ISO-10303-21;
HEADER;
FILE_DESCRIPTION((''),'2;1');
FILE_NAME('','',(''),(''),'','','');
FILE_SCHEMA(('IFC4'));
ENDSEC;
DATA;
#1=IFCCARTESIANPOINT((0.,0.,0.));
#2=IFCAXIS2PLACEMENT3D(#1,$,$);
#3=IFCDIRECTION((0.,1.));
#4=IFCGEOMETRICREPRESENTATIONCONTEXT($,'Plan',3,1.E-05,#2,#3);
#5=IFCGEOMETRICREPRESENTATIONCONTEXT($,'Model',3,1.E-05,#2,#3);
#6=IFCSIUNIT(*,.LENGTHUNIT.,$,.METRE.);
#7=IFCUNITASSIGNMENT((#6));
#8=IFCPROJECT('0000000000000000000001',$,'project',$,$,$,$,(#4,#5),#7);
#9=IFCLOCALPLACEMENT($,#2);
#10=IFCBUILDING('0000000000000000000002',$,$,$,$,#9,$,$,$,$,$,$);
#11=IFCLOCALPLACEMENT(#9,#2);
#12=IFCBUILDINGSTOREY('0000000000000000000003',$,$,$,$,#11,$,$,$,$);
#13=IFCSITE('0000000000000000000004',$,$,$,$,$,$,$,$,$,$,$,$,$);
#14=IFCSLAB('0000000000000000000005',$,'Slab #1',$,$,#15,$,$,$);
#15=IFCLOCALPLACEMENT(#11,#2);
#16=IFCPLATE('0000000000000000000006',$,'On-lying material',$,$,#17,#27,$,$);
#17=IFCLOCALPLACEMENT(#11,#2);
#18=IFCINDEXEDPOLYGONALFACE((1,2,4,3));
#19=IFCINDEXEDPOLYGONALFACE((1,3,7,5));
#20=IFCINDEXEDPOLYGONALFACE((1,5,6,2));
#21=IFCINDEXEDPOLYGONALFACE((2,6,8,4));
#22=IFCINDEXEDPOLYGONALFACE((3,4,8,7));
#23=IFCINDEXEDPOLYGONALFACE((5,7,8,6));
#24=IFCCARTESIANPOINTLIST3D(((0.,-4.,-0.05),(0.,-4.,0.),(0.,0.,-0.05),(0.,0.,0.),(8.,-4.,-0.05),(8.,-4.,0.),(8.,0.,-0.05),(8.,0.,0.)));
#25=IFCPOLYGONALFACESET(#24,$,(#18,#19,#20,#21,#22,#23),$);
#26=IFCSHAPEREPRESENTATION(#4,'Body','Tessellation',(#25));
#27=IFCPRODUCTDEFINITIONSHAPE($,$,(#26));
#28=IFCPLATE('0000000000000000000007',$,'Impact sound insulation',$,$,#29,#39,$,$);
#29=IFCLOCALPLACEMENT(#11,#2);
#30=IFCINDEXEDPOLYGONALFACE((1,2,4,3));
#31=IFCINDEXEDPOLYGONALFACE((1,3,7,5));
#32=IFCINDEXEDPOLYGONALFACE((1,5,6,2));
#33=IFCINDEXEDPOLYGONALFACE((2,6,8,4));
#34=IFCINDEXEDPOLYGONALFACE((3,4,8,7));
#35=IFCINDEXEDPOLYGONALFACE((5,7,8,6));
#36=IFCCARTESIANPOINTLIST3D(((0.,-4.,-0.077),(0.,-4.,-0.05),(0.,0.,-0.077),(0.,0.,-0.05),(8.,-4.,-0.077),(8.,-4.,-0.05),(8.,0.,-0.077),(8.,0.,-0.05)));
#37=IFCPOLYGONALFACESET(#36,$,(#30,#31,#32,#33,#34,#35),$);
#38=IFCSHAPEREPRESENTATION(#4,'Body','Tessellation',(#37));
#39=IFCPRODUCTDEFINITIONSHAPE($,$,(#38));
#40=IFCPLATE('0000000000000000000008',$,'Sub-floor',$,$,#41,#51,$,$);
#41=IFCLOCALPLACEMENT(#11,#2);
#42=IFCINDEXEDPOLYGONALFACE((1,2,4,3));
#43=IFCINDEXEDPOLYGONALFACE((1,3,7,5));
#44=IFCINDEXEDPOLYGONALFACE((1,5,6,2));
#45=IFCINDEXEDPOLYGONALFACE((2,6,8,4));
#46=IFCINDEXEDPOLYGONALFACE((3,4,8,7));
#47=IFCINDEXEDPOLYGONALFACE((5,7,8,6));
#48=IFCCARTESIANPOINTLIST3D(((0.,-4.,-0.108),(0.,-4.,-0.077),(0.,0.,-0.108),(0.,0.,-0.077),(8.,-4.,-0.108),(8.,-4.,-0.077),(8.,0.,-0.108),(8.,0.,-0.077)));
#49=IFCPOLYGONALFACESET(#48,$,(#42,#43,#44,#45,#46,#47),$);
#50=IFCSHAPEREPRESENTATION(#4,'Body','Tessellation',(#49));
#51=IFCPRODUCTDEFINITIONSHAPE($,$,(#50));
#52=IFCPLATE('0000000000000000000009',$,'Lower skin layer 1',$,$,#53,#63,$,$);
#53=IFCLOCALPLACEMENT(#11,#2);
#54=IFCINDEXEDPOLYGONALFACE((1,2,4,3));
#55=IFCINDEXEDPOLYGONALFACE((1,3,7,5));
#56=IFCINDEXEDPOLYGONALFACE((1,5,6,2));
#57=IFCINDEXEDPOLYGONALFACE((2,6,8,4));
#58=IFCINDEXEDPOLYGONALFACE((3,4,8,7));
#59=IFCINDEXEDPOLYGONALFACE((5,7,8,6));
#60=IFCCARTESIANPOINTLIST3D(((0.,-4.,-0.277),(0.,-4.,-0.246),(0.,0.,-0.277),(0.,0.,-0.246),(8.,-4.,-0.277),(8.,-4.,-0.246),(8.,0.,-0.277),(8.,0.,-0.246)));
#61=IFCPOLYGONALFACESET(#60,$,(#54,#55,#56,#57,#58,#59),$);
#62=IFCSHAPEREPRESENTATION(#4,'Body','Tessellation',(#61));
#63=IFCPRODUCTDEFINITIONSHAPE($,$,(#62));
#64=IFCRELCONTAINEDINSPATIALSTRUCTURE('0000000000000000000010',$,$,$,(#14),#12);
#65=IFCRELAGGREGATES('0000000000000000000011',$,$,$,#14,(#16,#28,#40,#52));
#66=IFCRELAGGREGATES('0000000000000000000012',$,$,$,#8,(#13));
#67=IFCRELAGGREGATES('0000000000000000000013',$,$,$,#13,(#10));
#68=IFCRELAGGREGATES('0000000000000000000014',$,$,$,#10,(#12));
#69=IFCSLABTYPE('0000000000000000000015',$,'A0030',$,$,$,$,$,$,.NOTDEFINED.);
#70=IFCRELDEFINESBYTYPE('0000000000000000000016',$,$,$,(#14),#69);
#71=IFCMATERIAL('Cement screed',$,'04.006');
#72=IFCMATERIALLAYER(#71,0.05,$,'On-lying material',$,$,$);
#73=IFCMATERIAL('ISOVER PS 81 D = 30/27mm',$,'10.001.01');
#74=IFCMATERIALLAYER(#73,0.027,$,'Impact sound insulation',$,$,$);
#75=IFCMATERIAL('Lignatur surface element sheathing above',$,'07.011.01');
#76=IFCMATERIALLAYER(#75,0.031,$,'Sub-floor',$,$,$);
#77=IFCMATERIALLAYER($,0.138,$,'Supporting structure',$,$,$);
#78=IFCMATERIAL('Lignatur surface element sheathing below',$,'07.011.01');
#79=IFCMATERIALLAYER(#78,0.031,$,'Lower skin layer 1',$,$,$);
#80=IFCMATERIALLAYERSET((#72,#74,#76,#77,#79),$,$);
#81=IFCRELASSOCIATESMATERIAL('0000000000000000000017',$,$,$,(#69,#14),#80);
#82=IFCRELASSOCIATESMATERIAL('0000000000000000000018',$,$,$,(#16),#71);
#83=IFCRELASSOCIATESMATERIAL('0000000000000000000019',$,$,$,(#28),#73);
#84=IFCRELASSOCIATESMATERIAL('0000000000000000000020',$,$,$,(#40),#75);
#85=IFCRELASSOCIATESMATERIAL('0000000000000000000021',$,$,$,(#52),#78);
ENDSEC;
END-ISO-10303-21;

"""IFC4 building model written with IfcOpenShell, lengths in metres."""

from ifc_helpers import new_model, si_unit, direction, frame, frame_2d, origin, origin_with_axes, place, context, project, spatial, rectangle, extrude, material, layer, layer_set, type_object, element, aggregate, save


model = new_model("IFC4")

# Units and contexts
plan_context = context("Plan", 3, precision=1e-05, world=origin(), true_north=direction((0.0, 1.0)))
model_context = context("Model", 3, precision=1e-05, world=origin(), true_north=direction((0.0, 1.0)))
ifc_project = project(units=[si_unit("LENGTHUNIT", "METRE")], contexts=[plan_context, model_context])

# Site, building, storey
site = spatial("IfcSite", under=ifc_project)
building_placement = place(None, origin())
building = spatial("IfcBuilding", under=site, at=building_placement)
storey_placement = place(building_placement, origin())
storey = spatial("IfcBuildingStorey", under=building, at=storey_placement)

# Slab, plates
ifc_material_1 = material(Name="Cement screed", Category="04.006")
ifc_layer_1 = layer(ifc_material_1, 0.05, Name="On-lying material")
ifc_material_2 = material(Name="ISOVER PS 81 D = 30/27mm", Category="10.001.01")
ifc_layer_2 = layer(ifc_material_2, 0.027, Name="Impact sound insulation")
ifc_material_3 = material(Name="Lignatur surface element sheathing above", Category="07.011.01")
ifc_layer_3 = layer(ifc_material_3, 0.031, Name="Sub-floor")
ifc_layer_4 = layer(None, 0.138, Name="Supporting structure")
ifc_material_4 = material(Name="Lignatur surface element sheathing below", Category="07.011.01")
ifc_layer_5 = layer(ifc_material_4, 0.031, Name="Lower skin layer 1")
ifc_layer_set = layer_set([ifc_layer_1, ifc_layer_2, ifc_layer_3, ifc_layer_4, ifc_layer_5])
slab_type = type_object("IfcSlabType", Name="A0030", PredefinedType="NOTDEFINED", material=ifc_layer_set)
slab_placement = place(None, frame((0.0, 0.0, 0.0), z_axis=(0.0, 0.0, -1.0), x_axis=(1.0, 0.0, 0.0)))
slab = element("IfcSlab", 1, at=slab_placement, inside=storey, type_object=slab_type, material=ifc_layer_set, Name="Slab #1")
plate_1_placement = place(slab_placement, origin())
plate_1 = element("IfcPlate", 2, at=plate_1_placement, material=ifc_material_1, Name="On-lying material", context=plan_context, shape_type="SweptSolid", body=[
    extrude(rectangle(XDim=8.0, YDim=4.0, at=frame_2d((4.0, 2.0), x_axis=(1.0, 0.0))), origin_with_axes(), (0.0, 0.0, 1.0), 0.05),
])
plate_2_placement = place(slab_placement, origin())
plate_2 = element("IfcPlate", 3, at=plate_2_placement, material=ifc_material_2, Name="Impact sound insulation", context=plan_context, shape_type="SweptSolid", body=[
    extrude(rectangle(XDim=8.0, YDim=4.0, at=frame_2d((4.0, 2.0), x_axis=(1.0, 0.0))), frame((0.0, 0.0, 0.05), z_axis=(0.0, 0.0, 1.0), x_axis=(1.0, 0.0, 0.0)), (0.0, 0.0, 1.0), 0.027),
])
plate_3_placement = place(slab_placement, origin())
plate_3 = element("IfcPlate", 4, at=plate_3_placement, material=ifc_material_3, Name="Sub-floor", context=plan_context, shape_type="SweptSolid", body=[
    extrude(rectangle(XDim=8.0, YDim=4.0, at=frame_2d((4.0, 2.0), x_axis=(1.0, 0.0))), frame((0.0, 0.0, 0.077), z_axis=(0.0, 0.0, 1.0), x_axis=(1.0, 0.0, 0.0)), (0.0, 0.0, 1.0), 0.031),
])
plate_4_placement = place(slab_placement, origin())
plate_4 = element("IfcPlate", 5, at=plate_4_placement, material=ifc_material_4, Name="Lower skin layer 1", context=plan_context, shape_type="SweptSolid", body=[
    extrude(rectangle(XDim=8.0, YDim=4.0, at=frame_2d((4.0, 2.0), x_axis=(1.0, 0.0))), frame((0.0, 0.0, 0.246), z_axis=(0.0, 0.0, 1.0), x_axis=(1.0, 0.0, 0.0)), (0.0, 0.0, 1.0), 0.031),
])
aggregate(slab, [plate_1, plate_2, plate_3, plate_4])

save(model, "model.ifc")
